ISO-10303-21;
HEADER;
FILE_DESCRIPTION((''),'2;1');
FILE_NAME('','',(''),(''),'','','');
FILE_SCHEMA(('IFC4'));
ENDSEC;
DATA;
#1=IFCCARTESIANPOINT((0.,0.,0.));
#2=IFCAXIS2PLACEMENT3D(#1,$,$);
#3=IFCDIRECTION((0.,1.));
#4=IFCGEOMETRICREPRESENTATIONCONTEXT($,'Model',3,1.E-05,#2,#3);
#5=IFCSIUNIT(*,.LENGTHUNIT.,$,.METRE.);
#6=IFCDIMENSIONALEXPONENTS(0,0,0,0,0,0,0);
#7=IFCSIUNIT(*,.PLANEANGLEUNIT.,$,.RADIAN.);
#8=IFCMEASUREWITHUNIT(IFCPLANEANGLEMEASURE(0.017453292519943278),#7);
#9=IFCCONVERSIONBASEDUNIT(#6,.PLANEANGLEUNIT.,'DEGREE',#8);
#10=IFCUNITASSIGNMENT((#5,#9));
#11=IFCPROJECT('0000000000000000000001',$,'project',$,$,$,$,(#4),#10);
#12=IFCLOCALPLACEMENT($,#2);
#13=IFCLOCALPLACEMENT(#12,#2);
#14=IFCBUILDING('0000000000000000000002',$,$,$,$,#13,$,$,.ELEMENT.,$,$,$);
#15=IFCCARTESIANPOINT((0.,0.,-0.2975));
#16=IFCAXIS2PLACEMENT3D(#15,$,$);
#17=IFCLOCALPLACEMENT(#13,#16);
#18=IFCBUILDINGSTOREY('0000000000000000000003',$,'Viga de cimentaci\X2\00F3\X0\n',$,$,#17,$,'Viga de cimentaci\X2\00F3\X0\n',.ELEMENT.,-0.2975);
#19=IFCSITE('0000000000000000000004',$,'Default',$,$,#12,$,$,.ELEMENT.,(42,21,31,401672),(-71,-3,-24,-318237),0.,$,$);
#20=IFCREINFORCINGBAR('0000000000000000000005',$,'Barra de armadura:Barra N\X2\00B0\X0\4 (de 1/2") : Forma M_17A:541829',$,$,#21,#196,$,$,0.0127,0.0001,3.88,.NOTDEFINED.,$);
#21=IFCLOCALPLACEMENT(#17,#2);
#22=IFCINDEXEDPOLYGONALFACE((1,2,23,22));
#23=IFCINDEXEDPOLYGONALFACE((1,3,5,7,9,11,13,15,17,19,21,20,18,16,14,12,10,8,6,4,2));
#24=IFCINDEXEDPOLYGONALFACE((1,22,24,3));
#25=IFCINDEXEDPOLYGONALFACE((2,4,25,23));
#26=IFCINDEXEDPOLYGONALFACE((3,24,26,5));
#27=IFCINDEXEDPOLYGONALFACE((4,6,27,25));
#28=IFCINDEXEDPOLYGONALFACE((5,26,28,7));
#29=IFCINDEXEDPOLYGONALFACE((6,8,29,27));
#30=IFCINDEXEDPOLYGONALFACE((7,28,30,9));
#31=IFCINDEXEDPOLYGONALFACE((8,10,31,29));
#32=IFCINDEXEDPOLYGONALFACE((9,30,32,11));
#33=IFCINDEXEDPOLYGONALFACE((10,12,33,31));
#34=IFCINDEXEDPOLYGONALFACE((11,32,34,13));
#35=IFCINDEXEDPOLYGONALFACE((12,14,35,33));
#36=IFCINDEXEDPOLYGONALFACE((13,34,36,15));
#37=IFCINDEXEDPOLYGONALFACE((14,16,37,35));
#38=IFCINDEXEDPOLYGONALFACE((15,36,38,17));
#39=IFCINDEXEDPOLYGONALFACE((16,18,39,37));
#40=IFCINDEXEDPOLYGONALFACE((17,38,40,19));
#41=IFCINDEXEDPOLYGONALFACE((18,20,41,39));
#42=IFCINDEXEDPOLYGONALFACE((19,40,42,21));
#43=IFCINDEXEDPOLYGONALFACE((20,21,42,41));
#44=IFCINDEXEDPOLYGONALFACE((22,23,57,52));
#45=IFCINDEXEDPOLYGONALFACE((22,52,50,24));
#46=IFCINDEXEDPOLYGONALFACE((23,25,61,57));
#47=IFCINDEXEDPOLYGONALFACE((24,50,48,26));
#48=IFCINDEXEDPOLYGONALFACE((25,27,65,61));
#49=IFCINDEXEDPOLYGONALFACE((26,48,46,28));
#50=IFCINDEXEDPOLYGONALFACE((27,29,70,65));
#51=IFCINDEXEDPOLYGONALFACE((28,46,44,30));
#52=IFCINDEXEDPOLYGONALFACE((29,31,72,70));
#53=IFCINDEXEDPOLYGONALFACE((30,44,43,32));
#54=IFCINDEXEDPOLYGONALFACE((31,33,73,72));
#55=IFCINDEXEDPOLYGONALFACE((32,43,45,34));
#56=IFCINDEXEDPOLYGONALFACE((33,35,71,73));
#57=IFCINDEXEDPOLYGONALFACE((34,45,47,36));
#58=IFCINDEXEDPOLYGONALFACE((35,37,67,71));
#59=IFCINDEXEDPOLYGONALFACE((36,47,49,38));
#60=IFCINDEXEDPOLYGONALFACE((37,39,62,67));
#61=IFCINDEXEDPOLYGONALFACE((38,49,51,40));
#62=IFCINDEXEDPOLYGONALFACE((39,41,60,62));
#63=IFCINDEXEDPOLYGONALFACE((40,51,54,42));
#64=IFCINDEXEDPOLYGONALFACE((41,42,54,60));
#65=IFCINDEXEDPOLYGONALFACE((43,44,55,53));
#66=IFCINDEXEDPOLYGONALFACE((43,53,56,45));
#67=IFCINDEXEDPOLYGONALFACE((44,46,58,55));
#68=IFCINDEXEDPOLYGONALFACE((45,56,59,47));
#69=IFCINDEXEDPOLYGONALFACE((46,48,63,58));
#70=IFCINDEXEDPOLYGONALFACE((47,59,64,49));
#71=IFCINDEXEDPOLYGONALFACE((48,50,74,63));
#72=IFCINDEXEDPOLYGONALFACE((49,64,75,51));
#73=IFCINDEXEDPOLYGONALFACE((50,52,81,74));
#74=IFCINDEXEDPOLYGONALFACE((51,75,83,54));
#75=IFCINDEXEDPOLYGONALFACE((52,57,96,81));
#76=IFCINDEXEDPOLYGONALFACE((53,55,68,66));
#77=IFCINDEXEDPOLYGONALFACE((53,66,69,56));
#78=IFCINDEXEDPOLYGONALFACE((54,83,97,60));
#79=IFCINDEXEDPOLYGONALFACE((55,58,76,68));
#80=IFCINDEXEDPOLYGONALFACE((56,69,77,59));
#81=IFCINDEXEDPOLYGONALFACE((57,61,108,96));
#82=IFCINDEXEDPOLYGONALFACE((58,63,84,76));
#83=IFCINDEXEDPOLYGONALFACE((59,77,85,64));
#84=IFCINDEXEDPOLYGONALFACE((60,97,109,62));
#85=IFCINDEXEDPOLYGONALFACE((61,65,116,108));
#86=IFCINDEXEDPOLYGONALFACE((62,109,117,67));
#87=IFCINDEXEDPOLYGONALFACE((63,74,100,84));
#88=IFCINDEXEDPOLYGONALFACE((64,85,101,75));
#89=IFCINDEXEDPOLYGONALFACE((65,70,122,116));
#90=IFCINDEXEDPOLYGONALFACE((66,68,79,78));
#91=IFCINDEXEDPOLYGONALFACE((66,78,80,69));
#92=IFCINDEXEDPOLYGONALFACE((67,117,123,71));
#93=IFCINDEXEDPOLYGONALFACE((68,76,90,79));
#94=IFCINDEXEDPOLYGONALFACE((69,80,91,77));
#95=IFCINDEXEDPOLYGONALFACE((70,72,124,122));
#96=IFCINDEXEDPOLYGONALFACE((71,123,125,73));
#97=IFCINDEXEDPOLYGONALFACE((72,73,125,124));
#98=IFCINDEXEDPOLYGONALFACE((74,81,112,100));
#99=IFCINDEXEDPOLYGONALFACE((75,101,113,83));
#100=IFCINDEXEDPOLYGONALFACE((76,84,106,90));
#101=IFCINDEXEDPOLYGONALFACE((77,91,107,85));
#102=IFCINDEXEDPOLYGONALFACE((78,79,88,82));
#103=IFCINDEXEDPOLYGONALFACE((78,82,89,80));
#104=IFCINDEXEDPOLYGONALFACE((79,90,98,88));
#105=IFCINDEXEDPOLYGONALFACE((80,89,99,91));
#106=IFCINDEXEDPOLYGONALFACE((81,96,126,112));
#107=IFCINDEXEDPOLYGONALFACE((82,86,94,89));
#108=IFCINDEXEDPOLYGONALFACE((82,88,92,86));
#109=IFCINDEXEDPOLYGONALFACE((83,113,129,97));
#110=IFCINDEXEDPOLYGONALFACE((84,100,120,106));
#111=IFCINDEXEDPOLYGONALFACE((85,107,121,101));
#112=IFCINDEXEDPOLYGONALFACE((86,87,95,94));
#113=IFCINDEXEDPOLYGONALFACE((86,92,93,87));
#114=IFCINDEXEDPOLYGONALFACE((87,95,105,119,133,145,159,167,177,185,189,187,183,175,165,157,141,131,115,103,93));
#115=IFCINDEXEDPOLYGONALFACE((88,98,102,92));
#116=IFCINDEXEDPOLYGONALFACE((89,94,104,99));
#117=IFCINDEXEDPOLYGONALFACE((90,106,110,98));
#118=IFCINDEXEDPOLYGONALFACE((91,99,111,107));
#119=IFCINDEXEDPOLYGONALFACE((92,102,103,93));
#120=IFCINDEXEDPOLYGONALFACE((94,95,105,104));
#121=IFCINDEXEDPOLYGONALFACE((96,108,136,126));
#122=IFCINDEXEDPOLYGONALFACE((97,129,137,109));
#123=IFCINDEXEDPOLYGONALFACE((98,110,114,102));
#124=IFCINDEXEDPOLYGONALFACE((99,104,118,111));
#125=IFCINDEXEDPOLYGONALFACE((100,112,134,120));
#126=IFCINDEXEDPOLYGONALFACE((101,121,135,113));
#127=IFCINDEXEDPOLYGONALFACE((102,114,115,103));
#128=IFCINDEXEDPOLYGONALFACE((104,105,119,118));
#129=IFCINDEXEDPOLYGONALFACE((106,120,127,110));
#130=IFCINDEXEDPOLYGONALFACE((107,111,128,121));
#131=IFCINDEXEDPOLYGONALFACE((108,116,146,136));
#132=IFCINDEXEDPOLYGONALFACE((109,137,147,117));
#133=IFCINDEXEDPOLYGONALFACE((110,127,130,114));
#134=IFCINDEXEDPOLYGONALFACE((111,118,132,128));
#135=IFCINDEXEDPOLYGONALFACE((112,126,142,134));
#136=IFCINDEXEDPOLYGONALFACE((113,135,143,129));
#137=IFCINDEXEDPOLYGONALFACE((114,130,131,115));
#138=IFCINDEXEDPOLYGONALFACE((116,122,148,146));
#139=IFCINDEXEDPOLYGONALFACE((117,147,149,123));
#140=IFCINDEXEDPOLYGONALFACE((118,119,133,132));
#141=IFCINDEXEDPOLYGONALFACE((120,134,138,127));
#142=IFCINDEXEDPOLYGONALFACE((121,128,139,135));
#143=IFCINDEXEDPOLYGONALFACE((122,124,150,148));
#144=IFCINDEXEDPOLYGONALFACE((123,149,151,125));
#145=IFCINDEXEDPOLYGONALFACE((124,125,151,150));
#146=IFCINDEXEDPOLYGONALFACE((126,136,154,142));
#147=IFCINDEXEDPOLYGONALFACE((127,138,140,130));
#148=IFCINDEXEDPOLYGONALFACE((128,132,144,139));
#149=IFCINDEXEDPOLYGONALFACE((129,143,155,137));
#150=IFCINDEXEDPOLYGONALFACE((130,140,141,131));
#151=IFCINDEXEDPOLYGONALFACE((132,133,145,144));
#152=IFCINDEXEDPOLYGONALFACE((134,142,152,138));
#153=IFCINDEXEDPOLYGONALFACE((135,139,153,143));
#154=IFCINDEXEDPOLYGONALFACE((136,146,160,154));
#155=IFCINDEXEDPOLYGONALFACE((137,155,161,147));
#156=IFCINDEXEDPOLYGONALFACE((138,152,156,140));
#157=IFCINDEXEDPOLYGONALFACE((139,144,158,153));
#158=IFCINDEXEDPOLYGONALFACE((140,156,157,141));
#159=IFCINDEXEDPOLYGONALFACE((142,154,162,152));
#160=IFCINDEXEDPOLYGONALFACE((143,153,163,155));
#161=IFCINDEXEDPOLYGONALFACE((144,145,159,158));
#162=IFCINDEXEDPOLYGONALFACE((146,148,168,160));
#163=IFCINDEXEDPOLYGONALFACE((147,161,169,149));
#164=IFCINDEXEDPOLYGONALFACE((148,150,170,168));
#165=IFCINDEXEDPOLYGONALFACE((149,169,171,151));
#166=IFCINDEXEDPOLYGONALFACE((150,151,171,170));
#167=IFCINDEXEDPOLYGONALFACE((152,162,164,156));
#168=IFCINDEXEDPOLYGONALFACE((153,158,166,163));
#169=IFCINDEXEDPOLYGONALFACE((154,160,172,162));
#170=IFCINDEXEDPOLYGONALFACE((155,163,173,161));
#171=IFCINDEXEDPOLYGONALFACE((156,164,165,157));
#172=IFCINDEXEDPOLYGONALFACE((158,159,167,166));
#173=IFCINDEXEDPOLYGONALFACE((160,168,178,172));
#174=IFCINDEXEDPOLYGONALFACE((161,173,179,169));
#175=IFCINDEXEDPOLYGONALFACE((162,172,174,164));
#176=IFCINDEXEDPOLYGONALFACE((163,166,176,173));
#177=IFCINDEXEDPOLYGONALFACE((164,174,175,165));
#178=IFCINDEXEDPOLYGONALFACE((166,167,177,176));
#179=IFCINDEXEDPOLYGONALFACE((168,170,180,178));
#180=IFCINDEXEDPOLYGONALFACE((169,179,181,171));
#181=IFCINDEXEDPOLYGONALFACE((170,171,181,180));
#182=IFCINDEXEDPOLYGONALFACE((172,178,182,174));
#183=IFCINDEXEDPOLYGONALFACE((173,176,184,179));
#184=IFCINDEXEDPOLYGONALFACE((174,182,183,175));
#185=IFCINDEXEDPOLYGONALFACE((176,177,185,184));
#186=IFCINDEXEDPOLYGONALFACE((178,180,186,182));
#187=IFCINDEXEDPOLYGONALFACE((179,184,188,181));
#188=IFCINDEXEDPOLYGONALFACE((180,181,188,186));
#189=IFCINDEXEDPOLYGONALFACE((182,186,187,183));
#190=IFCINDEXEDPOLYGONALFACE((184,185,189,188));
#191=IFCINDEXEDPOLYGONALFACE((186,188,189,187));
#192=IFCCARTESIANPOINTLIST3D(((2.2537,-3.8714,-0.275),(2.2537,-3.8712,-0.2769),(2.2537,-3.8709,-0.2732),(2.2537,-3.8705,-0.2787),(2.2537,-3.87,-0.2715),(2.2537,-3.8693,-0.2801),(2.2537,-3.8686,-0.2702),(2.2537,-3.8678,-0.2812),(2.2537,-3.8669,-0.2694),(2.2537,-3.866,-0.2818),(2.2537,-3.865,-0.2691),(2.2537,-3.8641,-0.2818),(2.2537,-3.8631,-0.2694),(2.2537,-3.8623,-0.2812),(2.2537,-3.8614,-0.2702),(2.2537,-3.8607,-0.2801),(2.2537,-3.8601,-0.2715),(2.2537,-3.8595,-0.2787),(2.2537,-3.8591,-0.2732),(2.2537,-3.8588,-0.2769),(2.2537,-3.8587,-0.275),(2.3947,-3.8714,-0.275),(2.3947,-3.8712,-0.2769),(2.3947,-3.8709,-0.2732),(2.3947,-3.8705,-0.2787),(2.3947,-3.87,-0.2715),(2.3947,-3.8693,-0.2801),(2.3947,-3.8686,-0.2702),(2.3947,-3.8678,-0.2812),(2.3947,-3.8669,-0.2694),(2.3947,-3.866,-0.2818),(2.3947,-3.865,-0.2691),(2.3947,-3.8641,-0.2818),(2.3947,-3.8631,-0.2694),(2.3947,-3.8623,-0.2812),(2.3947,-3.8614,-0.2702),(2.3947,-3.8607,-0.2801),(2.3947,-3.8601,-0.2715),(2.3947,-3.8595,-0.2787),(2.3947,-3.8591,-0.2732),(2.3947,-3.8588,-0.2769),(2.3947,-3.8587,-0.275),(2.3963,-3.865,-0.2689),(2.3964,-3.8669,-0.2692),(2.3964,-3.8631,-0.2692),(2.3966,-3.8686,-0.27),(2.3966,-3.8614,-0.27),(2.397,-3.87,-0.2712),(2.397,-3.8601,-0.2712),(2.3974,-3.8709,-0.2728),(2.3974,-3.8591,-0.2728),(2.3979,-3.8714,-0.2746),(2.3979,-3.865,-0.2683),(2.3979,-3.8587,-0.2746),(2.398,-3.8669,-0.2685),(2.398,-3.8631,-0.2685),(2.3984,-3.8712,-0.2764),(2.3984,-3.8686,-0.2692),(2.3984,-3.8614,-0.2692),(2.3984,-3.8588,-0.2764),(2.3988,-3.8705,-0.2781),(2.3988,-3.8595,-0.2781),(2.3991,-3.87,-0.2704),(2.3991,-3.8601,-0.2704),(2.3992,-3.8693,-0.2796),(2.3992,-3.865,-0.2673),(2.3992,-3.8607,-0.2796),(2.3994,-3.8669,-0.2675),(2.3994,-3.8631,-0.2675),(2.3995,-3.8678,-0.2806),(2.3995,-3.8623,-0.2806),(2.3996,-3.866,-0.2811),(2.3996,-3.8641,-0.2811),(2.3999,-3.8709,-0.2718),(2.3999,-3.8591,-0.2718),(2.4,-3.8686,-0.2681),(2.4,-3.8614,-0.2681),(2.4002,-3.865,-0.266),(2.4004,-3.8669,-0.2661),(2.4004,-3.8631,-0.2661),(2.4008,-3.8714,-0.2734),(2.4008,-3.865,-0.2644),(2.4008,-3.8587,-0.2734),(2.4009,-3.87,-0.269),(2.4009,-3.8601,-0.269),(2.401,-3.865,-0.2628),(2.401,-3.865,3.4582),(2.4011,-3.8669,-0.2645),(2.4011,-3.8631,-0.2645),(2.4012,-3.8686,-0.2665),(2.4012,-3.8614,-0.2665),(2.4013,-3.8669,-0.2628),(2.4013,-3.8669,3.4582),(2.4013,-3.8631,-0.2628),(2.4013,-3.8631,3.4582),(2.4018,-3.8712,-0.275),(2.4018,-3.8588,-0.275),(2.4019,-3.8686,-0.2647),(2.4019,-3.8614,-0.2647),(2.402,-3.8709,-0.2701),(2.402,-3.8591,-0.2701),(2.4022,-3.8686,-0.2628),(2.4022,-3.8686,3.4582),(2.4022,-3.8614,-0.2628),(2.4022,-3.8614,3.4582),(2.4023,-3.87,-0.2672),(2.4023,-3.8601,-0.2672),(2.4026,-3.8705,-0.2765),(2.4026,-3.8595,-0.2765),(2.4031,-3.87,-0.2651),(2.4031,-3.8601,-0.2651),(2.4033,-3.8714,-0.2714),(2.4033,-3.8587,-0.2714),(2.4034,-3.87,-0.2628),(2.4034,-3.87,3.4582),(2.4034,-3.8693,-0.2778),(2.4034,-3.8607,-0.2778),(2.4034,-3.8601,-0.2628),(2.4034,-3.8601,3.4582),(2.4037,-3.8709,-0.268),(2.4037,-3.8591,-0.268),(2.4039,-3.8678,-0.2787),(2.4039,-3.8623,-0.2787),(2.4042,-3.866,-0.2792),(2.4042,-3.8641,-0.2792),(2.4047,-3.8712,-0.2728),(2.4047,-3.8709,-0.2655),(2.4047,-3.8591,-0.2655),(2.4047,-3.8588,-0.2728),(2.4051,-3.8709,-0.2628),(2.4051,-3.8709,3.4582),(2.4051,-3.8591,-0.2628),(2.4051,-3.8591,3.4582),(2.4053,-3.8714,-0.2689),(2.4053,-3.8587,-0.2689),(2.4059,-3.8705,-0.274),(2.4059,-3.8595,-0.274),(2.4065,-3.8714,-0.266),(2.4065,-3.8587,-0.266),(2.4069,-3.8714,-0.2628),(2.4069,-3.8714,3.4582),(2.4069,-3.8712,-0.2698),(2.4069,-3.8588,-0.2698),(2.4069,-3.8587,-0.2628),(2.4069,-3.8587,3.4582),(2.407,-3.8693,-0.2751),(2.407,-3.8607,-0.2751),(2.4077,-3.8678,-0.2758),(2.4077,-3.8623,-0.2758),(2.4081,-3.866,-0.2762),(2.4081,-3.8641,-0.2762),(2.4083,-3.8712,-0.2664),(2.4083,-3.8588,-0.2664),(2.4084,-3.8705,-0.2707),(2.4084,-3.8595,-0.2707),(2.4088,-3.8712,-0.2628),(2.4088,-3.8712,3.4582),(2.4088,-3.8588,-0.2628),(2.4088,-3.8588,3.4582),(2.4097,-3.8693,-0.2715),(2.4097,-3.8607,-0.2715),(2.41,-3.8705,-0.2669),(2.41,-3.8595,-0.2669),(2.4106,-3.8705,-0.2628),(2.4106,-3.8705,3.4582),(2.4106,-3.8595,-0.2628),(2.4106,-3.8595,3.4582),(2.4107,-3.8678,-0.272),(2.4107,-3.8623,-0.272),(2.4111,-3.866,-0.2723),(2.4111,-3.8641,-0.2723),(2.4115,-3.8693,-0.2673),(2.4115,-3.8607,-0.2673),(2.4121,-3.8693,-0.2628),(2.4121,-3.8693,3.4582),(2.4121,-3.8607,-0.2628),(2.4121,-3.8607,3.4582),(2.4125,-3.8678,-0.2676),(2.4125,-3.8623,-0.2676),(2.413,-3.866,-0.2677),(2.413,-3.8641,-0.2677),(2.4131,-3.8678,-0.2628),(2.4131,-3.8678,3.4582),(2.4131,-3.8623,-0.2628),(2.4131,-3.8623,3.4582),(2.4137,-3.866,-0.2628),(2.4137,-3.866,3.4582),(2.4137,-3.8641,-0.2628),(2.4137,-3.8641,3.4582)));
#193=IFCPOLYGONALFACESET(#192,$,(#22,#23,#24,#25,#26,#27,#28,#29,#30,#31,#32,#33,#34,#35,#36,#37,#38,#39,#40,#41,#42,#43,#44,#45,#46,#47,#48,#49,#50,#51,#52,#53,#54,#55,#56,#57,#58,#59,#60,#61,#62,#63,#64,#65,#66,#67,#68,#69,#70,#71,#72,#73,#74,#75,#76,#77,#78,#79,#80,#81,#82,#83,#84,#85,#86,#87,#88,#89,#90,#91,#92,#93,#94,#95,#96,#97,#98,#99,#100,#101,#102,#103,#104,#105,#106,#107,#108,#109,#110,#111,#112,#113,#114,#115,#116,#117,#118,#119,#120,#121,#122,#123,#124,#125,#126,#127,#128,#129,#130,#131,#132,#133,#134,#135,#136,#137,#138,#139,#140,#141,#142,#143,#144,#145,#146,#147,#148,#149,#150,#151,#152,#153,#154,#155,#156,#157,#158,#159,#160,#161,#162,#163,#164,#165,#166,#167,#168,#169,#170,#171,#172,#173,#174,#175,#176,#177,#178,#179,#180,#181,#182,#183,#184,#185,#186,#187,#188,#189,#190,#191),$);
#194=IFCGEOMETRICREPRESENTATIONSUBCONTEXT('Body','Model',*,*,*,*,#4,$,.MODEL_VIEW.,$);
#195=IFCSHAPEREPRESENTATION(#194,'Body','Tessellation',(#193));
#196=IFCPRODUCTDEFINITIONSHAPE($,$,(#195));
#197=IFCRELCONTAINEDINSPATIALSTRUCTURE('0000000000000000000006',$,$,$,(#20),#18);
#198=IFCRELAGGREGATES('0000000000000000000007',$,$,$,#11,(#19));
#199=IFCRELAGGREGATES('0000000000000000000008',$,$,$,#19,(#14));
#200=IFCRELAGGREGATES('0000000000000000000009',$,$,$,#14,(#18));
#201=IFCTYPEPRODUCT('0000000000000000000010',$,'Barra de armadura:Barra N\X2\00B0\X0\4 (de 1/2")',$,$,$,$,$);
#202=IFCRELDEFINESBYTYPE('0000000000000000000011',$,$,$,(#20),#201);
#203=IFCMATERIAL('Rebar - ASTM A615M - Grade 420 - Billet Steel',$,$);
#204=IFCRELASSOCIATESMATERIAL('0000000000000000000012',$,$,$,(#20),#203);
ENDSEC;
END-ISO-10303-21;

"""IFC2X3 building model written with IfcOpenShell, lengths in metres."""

from ifc_helpers import new_model, entity, si_unit, converted_unit, direction, frame, origin, place, context, subcontext, project, spatial, material, type_object, element, save


model = new_model("IFC2X3")

# Units and contexts
model_context = context("Model", 3, precision=1e-05, world=origin(), true_north=direction((0.0, 1.0)))
body_context = subcontext(model_context, "Body", "Model", "MODEL_VIEW")
ifc_project = project(units=[si_unit("LENGTHUNIT", "METRE"), converted_unit("PLANEANGLEUNIT", "DEGREE", entity("IfcPlaneAngleMeasure", 0.017453292519943278), si_unit("PLANEANGLEUNIT", "RADIAN"), dimensions=[0, 0, 0, 0, 0, 0, 0])], contexts=[model_context])

# Site, building, storey
site_placement = place(None, origin())
site = spatial("IfcSite", under=ifc_project, at=site_placement, Name="Default", CompositionType="ELEMENT", RefLatitude=(42, 21, 31, 401672), RefLongitude=(-71, -3, -24, -318237), RefElevation=0.0)
building_placement = place(site_placement, origin())
building = spatial("IfcBuilding", under=site, at=building_placement, CompositionType="ELEMENT")
storey_placement = place(building_placement, frame((0.0, 0.0, -0.2975)))
storey = spatial("IfcBuildingStorey", under=building, at=storey_placement, Name="Viga de cimentación", LongName="Viga de cimentación", CompositionType="ELEMENT", Elevation=-0.2975)

# Reinforcing bar
ifc_material_1 = material(Name="Rebar - ASTM A615M - Grade 420 - Billet Steel")
type_product_1 = type_object("IfcTypeProduct", Name="Barra de armadura:Barra N°4 (de 1/2\")")
reinforcing_bar_1_placement = place(storey_placement, origin())
element("IfcReinforcingBar", 1, at=reinforcing_bar_1_placement, inside=storey, type_object=type_product_1, material=ifc_material_1, Name="Barra de armadura:Barra N°4 (de 1/2\") : Forma M_17A:541829", BarLength=3.88, BarRole="NOTDEFINED", CrossSectionArea=0.0001, NominalDiameter=0.0127, context=body_context, shape_type="AdvancedSweptSolid", body=[
    entity("IfcSweptDiskSolid", entity("IfcCompositeCurve", [entity("IfcCompositeCurveSegment", "CONTINUOUS", True, entity("IfcPolyline", [entity("IfcCartesianPoint", [2.4074, -3.865, 3.4582]), entity("IfcCartesianPoint", [2.4074, -3.865, -0.2628])])), entity("IfcCompositeCurveSegment", "CONTINUOUS", True, entity("IfcTrimmedCurve", entity("IfcCircle", entity("IfcAxis2Placement3D", entity("IfcCartesianPoint", [2.3947, -3.865, -0.2628]), entity("IfcDirection", [0.0, 1.0, 0.0]), entity("IfcDirection", [0.0, 0.0, -1.0])), 0.0127), [entity("IfcParameterValue", 270.0)], [entity("IfcParameterValue", 360.0)], True, "PARAMETER")), entity("IfcCompositeCurveSegment", "CONTINUOUS", True, entity("IfcPolyline", [entity("IfcCartesianPoint", [2.3947, -3.865, -0.2755]), entity("IfcCartesianPoint", [2.2537, -3.865, -0.2755])]))], False), 0.0063, None, 0.0, 92.0),
])

save(model, "model.ifc")
